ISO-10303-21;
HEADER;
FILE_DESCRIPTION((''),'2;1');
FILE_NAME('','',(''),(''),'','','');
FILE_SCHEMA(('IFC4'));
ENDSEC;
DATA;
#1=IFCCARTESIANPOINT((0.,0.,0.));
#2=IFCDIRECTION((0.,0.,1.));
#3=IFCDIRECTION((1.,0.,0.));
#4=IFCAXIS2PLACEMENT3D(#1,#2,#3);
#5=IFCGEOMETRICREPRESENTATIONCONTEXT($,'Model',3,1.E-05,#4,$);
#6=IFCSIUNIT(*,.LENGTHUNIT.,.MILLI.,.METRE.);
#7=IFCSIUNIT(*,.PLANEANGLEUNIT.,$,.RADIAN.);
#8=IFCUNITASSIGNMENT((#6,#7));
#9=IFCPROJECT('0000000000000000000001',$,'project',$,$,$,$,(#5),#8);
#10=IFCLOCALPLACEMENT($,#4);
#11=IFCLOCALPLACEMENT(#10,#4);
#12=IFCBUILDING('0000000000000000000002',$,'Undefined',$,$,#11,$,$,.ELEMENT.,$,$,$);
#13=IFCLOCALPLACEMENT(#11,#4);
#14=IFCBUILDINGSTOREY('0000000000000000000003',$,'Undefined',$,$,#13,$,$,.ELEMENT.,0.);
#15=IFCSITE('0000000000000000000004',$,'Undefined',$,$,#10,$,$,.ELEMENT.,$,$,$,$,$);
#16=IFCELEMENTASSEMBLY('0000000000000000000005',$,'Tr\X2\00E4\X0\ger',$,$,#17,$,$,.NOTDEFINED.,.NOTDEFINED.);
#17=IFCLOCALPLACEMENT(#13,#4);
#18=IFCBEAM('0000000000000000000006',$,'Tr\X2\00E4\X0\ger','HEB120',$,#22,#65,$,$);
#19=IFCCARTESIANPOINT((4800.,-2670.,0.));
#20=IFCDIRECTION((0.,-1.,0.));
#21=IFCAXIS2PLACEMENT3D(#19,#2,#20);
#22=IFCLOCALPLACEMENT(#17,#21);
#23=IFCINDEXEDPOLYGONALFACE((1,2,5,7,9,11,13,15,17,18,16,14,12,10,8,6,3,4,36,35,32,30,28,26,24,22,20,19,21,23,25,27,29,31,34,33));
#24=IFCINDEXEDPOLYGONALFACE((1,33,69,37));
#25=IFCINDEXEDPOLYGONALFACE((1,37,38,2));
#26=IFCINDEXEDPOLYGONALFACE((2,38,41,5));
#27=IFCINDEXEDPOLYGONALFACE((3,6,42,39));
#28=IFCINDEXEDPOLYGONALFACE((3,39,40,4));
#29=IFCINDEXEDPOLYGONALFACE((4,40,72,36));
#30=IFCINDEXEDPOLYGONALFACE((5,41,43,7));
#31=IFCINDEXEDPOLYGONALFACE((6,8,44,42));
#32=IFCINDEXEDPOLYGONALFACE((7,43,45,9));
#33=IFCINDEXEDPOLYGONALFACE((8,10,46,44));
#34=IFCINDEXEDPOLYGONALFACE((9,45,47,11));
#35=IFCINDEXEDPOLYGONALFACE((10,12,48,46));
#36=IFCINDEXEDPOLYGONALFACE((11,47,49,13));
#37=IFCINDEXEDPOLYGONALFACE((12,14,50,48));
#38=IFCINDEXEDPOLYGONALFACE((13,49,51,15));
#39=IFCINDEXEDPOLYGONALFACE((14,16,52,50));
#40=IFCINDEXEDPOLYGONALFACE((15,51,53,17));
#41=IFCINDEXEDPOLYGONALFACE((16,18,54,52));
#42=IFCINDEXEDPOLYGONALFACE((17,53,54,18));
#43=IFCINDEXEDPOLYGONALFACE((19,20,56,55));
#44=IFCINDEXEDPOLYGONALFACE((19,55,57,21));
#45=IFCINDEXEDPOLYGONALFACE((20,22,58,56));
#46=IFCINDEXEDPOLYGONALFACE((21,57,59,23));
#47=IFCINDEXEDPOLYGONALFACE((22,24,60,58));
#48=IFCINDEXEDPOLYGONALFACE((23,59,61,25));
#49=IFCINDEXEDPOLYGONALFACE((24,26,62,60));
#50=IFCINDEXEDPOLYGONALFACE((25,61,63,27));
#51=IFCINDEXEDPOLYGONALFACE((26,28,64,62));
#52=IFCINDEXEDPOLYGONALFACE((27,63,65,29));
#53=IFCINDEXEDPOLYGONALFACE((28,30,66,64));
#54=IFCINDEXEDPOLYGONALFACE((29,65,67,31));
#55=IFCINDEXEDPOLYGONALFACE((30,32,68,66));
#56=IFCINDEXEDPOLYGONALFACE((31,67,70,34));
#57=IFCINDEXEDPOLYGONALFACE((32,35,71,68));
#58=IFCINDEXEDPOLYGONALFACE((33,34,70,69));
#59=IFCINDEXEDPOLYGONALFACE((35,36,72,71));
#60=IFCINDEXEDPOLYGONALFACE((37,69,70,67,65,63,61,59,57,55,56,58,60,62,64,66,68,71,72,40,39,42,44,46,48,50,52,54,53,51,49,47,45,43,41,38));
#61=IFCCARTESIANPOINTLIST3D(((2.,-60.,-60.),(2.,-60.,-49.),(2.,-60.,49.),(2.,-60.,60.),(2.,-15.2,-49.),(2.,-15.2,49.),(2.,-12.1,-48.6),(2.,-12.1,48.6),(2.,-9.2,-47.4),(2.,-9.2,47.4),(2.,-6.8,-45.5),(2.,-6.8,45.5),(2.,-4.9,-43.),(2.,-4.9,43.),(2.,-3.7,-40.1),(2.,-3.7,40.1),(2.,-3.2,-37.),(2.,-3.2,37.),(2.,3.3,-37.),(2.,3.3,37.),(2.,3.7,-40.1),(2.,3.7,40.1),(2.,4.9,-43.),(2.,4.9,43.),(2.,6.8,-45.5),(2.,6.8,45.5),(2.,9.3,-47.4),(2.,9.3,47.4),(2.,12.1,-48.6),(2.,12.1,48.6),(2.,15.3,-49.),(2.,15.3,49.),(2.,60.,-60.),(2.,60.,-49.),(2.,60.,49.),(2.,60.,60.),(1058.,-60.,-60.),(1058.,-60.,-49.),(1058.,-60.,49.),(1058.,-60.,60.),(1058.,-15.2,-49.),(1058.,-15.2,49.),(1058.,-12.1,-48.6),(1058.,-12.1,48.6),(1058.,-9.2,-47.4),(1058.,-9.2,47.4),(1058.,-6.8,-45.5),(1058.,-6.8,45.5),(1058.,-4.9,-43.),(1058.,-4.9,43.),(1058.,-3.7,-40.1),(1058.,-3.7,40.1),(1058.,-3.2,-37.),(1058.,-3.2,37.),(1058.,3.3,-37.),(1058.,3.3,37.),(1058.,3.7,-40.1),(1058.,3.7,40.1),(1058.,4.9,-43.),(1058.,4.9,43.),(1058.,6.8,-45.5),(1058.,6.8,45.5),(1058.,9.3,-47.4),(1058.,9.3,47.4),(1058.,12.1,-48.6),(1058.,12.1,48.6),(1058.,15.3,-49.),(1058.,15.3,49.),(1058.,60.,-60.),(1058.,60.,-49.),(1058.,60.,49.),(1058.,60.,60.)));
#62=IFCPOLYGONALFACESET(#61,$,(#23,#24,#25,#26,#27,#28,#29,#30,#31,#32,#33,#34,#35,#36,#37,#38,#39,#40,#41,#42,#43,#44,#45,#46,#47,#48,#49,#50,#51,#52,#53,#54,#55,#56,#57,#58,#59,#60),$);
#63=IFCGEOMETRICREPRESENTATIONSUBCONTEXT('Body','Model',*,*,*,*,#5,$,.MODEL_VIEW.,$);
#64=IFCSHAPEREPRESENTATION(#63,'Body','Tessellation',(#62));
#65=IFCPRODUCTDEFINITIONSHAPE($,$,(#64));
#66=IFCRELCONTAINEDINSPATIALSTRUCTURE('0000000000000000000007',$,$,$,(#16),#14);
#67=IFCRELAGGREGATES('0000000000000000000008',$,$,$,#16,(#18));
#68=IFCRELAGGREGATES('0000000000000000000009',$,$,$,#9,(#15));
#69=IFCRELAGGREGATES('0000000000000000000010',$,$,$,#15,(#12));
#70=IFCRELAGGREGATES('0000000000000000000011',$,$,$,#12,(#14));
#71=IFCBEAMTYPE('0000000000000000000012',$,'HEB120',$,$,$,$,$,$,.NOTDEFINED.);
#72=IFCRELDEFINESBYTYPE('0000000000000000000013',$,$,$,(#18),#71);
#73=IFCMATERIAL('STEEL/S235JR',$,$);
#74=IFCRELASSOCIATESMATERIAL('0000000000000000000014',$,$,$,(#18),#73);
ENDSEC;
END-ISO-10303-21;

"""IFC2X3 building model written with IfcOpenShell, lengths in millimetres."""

from ifc_helpers import new_model, si_unit, frame, origin_with_axes, origin_2d_with_axis, place, context, subcontext, project, spatial, i_section, extrude, clip, halfspace, material, type_object, element, aggregate, save


model = new_model("IFC2X3")

# Units and contexts
model_context = context("Model", 3, precision=1e-05, world=origin_with_axes())
body_context = subcontext(model_context, "Body", "Model", "MODEL_VIEW")
ifc_project = project(units=[si_unit("LENGTHUNIT", "METRE", prefix="MILLI"), si_unit("PLANEANGLEUNIT", "RADIAN")], contexts=[model_context])

# Site, building, storey
site_placement = place(None, origin_with_axes())
site = spatial("IfcSite", under=ifc_project, at=site_placement, Name="Undefined", CompositionType="ELEMENT")
building_placement = place(site_placement, origin_with_axes())
building = spatial("IfcBuilding", under=site, at=building_placement, Name="Undefined", CompositionType="ELEMENT")
storey_placement = place(building_placement, origin_with_axes())
storey = spatial("IfcBuildingStorey", under=building, at=storey_placement, Name="Undefined", CompositionType="ELEMENT", Elevation=0.0)

# Shared definitions
ifc_material_1 = material(Name="STEEL/S235JR")

# Element assembly, beam
beam_type_1 = type_object("IfcBeamType", Name="HEB120", PredefinedType="NOTDEFINED")
assembly_1_placement = place(storey_placement, origin_with_axes())
assembly_1 = element("IfcElementAssembly", 1, at=assembly_1_placement, inside=storey, Name="Träger", AssemblyPlace="NOTDEFINED", PredefinedType="NOTDEFINED")
beam_1_placement = place(assembly_1_placement, frame((4800.0, -2670.0, 0.0), z_axis=(0.0, 0.0, 1.0), x_axis=(0.0, -1.0, 0.0)))
beam_1 = element("IfcBeam", 2, at=beam_1_placement, type_object=beam_type_1, material=ifc_material_1, Name="Träger", Description="HEB120", context=body_context, shape_type="Clipping", body=[
    clip(clip(extrude(i_section(OverallWidth=120.0, OverallDepth=120.0, WebThickness=6.5, FlangeThickness=11.0, FilletRadius=12.0, at=origin_2d_with_axis()), frame((1060.0, 0.0, 0.0), z_axis=(-1.0, 0.0, 0.0), x_axis=(0.0, -1.0, 0.0)), (0.0, 0.0, 1.0), 1060.0), halfspace(frame((1058.0, 0.0, -60.0), z_axis=(-1.0, 0.0, 0.0), x_axis=(0.0, 1.0, 0.0)), True)), halfspace(frame((2.0, 0.0, -60.0), z_axis=(1.0, 0.0, 0.0), x_axis=(0.0, -1.0, 0.0)), True)),
])

aggregate(assembly_1, [beam_1])

save(model, "model.ifc")
